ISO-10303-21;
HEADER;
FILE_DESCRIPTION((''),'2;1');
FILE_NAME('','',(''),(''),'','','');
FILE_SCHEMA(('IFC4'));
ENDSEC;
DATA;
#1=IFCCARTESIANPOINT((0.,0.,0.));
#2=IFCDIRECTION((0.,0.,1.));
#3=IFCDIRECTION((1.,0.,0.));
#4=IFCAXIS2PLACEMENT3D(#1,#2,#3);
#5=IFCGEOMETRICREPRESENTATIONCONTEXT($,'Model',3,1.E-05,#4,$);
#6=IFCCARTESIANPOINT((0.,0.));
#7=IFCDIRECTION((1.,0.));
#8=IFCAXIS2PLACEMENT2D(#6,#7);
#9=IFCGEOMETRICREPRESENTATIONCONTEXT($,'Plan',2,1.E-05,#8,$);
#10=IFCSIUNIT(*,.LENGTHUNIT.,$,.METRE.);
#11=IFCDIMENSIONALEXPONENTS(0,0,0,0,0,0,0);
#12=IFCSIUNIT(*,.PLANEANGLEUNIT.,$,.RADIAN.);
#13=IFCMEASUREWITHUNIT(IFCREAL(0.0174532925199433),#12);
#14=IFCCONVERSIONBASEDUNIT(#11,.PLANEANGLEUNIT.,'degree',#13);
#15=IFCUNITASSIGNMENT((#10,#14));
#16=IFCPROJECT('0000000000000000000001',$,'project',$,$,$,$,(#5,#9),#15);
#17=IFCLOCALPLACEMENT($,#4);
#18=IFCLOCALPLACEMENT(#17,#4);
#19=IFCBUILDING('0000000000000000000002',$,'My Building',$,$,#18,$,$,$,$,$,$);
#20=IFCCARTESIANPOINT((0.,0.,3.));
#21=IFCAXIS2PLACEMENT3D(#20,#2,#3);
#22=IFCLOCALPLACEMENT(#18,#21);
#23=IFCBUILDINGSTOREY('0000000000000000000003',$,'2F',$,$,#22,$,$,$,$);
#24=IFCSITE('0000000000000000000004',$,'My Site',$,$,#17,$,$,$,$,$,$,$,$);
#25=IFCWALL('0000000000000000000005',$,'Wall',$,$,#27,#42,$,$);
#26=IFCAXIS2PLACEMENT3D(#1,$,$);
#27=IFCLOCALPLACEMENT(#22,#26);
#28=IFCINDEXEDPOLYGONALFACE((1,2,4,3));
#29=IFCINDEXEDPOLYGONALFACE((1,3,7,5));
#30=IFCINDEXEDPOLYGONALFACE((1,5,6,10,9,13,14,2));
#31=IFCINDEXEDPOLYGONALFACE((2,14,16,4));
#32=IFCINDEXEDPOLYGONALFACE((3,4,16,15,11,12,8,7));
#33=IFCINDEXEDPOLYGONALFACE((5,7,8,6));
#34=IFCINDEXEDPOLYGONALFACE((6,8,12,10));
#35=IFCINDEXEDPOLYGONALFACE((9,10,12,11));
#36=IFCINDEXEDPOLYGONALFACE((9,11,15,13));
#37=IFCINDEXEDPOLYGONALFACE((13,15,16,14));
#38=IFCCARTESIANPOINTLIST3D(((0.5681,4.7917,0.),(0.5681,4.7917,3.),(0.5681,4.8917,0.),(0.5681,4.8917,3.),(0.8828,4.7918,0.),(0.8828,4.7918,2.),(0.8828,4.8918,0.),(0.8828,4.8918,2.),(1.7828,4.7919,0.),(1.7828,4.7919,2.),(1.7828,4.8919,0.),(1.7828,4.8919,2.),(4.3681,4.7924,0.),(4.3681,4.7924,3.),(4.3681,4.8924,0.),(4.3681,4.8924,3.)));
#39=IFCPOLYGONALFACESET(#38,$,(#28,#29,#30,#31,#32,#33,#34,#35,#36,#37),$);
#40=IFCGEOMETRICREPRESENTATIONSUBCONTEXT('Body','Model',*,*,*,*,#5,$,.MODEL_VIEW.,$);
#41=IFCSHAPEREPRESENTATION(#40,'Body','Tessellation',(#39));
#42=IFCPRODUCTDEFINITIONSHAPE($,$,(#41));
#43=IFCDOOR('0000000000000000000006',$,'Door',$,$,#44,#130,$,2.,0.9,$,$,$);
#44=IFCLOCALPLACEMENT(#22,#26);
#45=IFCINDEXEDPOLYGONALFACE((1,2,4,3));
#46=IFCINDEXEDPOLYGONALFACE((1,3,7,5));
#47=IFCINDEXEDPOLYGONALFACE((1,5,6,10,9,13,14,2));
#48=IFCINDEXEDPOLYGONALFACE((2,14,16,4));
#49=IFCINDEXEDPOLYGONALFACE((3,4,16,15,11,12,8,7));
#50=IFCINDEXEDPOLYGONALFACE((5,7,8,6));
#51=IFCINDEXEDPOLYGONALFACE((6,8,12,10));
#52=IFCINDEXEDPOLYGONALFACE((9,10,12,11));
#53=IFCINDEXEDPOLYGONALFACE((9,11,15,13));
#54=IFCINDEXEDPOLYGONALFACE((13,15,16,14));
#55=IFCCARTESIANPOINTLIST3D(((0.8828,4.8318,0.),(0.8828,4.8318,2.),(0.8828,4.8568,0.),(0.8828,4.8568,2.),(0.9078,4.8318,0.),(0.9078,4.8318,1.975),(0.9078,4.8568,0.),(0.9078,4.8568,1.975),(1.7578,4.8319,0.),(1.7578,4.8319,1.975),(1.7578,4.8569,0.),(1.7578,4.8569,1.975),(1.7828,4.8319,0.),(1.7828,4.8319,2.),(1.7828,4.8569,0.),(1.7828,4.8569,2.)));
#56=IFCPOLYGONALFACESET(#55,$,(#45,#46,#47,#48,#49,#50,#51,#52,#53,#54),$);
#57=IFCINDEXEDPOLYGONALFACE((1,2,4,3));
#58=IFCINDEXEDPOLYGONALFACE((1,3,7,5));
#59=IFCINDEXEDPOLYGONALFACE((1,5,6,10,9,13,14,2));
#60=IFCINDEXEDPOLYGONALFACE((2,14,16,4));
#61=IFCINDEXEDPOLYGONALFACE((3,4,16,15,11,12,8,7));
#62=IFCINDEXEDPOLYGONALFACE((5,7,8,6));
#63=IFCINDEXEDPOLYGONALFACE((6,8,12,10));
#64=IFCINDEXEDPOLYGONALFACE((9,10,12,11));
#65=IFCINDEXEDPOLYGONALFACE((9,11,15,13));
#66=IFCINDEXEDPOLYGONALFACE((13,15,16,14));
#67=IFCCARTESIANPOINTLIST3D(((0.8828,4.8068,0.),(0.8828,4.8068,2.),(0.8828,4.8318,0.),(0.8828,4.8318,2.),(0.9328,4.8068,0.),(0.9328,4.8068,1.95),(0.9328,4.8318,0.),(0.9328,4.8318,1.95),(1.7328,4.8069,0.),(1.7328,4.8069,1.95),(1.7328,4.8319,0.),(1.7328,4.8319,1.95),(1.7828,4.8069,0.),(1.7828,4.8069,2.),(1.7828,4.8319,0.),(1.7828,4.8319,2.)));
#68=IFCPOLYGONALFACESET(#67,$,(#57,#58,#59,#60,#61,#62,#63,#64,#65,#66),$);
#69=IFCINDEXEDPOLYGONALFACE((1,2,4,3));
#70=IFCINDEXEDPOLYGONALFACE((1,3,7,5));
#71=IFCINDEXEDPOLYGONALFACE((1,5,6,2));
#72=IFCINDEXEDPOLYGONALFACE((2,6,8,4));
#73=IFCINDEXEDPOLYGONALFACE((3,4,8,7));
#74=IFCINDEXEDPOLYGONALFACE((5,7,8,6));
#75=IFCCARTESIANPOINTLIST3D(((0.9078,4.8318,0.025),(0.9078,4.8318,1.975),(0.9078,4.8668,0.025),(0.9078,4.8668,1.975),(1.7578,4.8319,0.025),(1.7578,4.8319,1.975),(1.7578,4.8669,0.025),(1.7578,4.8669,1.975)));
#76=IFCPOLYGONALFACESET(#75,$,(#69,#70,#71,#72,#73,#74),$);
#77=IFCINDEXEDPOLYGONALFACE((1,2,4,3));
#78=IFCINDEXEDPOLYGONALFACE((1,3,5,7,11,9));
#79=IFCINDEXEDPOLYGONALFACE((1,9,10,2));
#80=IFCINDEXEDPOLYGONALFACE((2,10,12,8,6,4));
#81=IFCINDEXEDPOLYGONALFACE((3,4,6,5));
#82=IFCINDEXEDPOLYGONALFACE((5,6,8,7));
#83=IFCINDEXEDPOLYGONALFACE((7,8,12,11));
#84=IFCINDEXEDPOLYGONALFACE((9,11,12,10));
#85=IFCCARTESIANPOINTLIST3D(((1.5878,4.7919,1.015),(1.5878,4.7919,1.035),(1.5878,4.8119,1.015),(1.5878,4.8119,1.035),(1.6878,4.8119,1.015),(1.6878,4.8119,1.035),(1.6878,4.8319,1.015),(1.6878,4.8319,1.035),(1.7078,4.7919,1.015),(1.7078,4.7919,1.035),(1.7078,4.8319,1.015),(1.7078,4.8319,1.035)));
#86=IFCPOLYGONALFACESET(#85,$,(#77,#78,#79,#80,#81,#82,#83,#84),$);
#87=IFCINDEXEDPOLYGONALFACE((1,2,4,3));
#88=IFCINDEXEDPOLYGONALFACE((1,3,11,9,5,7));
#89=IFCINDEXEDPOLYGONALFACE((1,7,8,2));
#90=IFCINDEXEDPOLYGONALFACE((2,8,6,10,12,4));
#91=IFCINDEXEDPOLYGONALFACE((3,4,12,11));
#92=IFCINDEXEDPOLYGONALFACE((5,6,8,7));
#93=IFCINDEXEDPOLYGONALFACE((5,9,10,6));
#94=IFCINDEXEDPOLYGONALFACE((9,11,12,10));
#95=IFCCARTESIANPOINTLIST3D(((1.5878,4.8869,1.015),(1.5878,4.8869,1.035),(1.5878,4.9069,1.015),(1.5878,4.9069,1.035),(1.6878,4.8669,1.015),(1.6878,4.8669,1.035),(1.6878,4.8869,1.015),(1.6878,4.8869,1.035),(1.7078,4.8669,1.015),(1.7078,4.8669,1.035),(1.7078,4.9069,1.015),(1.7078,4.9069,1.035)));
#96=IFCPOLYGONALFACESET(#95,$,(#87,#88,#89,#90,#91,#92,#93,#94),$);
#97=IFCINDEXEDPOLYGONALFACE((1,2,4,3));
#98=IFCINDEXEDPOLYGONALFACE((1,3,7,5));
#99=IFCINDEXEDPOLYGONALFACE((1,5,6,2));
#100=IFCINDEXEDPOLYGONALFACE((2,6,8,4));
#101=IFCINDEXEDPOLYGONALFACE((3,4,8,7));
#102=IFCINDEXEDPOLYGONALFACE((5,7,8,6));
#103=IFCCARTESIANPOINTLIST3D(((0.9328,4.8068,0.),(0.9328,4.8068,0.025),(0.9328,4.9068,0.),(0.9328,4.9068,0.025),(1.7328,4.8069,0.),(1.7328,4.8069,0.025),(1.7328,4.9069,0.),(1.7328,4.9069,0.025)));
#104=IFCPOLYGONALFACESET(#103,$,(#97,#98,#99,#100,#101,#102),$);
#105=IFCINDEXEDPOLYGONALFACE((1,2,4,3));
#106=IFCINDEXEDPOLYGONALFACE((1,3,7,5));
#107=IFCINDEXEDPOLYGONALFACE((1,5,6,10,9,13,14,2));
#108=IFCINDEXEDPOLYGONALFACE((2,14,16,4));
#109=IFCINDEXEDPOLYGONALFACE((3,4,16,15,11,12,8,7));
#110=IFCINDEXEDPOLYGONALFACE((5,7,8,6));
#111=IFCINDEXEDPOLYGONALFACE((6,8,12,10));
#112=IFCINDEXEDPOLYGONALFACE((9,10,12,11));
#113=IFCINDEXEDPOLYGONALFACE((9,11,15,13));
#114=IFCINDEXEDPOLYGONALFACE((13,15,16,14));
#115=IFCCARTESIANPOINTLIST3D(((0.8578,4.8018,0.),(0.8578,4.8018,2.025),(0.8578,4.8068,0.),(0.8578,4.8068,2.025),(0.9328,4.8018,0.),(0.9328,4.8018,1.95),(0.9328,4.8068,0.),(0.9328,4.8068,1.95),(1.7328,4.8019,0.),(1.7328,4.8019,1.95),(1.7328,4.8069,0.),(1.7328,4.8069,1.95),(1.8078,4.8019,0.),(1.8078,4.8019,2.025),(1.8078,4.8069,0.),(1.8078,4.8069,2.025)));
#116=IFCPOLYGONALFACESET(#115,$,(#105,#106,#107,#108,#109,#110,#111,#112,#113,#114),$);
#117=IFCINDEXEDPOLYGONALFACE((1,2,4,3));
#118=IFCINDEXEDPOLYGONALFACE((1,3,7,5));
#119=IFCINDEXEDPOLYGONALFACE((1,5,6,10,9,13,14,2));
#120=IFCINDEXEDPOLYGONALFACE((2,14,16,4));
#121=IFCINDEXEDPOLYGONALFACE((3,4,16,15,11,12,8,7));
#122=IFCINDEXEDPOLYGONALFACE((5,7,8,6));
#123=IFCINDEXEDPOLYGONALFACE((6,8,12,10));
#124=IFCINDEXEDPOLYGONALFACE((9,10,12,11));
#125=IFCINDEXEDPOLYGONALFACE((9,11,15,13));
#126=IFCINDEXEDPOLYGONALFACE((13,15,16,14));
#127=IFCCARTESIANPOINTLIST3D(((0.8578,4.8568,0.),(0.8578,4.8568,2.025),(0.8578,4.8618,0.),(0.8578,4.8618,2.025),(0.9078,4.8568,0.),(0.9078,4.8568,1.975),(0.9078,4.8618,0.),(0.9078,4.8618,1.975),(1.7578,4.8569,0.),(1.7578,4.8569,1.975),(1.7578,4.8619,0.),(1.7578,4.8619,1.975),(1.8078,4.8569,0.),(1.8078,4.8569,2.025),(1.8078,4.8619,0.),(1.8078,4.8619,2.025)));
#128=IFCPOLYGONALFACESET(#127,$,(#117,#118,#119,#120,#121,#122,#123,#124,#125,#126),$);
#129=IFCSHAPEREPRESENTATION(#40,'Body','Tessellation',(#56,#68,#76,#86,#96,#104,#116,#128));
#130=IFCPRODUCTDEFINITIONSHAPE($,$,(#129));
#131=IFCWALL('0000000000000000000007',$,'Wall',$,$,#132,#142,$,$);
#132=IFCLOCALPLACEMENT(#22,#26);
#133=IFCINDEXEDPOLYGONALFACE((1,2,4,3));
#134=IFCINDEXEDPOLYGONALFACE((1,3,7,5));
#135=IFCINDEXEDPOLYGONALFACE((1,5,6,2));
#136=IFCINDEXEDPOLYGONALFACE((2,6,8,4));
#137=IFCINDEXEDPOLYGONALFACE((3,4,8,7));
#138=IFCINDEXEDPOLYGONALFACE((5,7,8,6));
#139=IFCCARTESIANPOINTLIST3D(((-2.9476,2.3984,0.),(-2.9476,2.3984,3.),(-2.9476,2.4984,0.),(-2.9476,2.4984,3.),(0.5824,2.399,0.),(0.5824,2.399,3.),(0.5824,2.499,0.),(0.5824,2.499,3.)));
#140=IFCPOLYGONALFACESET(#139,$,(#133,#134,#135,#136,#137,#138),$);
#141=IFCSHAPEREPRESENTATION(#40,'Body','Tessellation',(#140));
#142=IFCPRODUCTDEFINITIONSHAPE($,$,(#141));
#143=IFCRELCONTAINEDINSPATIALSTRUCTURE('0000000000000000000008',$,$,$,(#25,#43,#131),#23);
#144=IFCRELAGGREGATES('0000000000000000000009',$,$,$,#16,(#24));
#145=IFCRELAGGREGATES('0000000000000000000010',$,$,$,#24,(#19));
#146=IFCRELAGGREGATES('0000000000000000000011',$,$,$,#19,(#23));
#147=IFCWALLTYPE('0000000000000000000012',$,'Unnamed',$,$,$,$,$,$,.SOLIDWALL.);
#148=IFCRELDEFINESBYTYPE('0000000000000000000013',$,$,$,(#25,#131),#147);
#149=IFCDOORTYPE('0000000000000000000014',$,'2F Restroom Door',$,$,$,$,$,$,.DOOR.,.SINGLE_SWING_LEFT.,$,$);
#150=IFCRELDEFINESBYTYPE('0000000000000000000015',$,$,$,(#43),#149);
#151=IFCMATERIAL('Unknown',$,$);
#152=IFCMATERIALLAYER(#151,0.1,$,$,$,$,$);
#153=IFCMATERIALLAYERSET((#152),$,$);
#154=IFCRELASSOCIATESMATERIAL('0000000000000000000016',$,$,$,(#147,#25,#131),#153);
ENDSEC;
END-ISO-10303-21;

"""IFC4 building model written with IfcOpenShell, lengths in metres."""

from ifc_helpers import new_model, entity, si_unit, converted_unit, frame, origin_with_axes, origin_2d_with_axis, place, context, subcontext, project, spatial, line, indexed_curve, outline, extrude, shape, source, transform, mapped, material, layer, layer_set, layer_usage, type_object, type_shapes, element, fill, save


model = new_model("IFC4")

# Units and contexts
model_context = context("Model", 3, precision=1e-05, world=origin_with_axes())
plan_context = context("Plan", 2, precision=1e-05, world=origin_2d_with_axis())
body_context_1 = subcontext(model_context, "Body", "Model", "MODEL_VIEW")
body_context_2 = subcontext(plan_context, "Body", "Plan", "PLAN_VIEW")
ifc_project = project(units=[si_unit("LENGTHUNIT", "METRE"), converted_unit("PLANEANGLEUNIT", "degree", entity("IfcReal", 0.0174532925199433), si_unit("PLANEANGLEUNIT", "RADIAN"), dimensions=[0, 0, 0, 0, 0, 0, 0])], contexts=[model_context, plan_context])

# Site, building, storey
site_placement = place(None, origin_with_axes())
site = spatial("IfcSite", under=ifc_project, at=site_placement, Name="My Site")
building_placement = place(site_placement, origin_with_axes())
building = spatial("IfcBuilding", under=site, at=building_placement, Name="My Building")
storey_placement = place(building_placement, frame((0.0, 0.0, 3.0), z_axis=(0.0, 0.0, 1.0), x_axis=(1.0, 0.0, 0.0)))
storey = spatial("IfcBuildingStorey", under=building, at=storey_placement, Name="2F")

# Shared definitions
ifc_material = material(Name="Unknown")

# Shared definitions
ifc_layer = layer(ifc_material, 0.1)
ifc_layer_set = layer_set([ifc_layer])
wall_type = type_object("IfcWallType", Name="Unnamed", PredefinedType="SOLIDWALL", material=ifc_layer_set)

# Wall, opening, door
ifc_layer_usage_1 = layer_usage(ifc_layer_set, "AXIS2", "POSITIVE", 0.0)
wall_1_placement = place(storey_placement, frame((4.3681, 4.8924, 0.0), z_axis=(0.0, 0.0, 1.0), x_axis=(-1.0, -0.000193, 0.0)))
wall_1 = element("IfcWall", 1, at=wall_1_placement, inside=storey, type_object=wall_type, material=ifc_layer_usage_1, Name="Wall", context=body_context_1, shape_type="SweptSolid", body=[
    extrude(outline(indexed_curve([(0.0, 0.0), (0.0, 0.1), (3.8, 0.1), (3.8, 0.0)], segments=[line(1, 2, 3, 4, 1)])), origin_with_axes(), (0.0, 0.0, 1.0), 3.0),
])
shared_shape_1 = source(origin_with_axes(), body_context_1, "Body", "SweptSolid", [
    extrude(outline(indexed_curve([(0.0, 0.0), (0.9, 0.0), (0.9, 2.0), (0.0, 2.0)], segments=[line(1, 2, 3, 4, 1)])), frame((0.0, -0.6, 0.0), z_axis=(0.0, -1.0, 0.0), x_axis=(1.0, 0.0, 0.0)), (0.0, 0.0, -1.0), 1.2),
])
opening_1_placement = place(wall_1_placement, frame((2.5853, 0.0, 0.0), z_axis=(0.0, 0.0, 1.0), x_axis=(1.0, 0.0, 0.0)))
opening_1 = element("IfcOpeningElement", 2, at=opening_1_placement, cuts=wall_1, PredefinedType="OPENING", context=body_context_1, shape_type="MappedRepresentation", body=[
    mapped(shared_shape_1, transform((0.0, 0.0, 0.0), x_axis=(1.0, 0.0, 0.0), y_axis=(0.0, 1.0, 0.0), z_axis=(0.0, 0.0, 1.0), scale=1.0)),
])
door_type_1 = type_object("IfcDoorType", Name="2F Restroom Door", OperationType="SINGLE_SWING_LEFT", PredefinedType="DOOR")
shared_shape_2 = source(origin_with_axes(), body_context_1, "Body", "SweptSolid", [
    extrude(outline(indexed_curve([(0.0, 0.0), (0.0, 2.0), (0.9, 2.0), (0.9, 0.0), (0.875, 0.0), (0.875, 1.975), (0.025, 1.975), (0.025, 0.0)], segments=[line(1, 2, 3, 4, 5, 6, 7, 8, 1)])), frame((0.0, 0.025, 0.0), z_axis=(0.0, -1.0, 0.0), x_axis=(1.0, 0.0, 0.0)), (0.0, 0.0, -1.0), 0.025),
    extrude(outline(indexed_curve([(0.0, 0.0), (0.0, 2.0), (0.9, 2.0), (0.9, 0.0), (0.85, 0.0), (0.85, 1.95), (0.05, 1.95), (0.05, 0.0)], segments=[line(1, 2, 3, 4, 5, 6, 7, 8, 1)])), frame((0.0, 0.0, 0.0), z_axis=(0.0, -1.0, 0.0), x_axis=(1.0, 0.0, 0.0)), (0.0, 0.0, -1.0), 0.025),
    extrude(outline(indexed_curve([(0.0, 0.0), (0.85, 0.0), (0.85, 0.035), (0.0, 0.035)], segments=[line(1, 2, 3, 4, 1)])), frame((0.025, 0.025, 0.025), z_axis=(0.0, 0.0, 1.0), x_axis=(1.0, 0.0, 0.0)), (0.0, 0.0, 1.0), 1.95),
    extrude(outline(indexed_curve([(0.0, 0.0), (0.0, -0.04), (-0.12, -0.04), (-0.12, -0.02), (-0.02, -0.02), (-0.02, 0.0)], segments=[line(1, 2, 3, 4, 5, 6, 1)])), frame((0.825, 0.025, 1.015), z_axis=(0.0, 0.0, 1.0), x_axis=(1.0, 0.0, 0.0)), (0.0, 0.0, 1.0), 0.02),
    extrude(outline(indexed_curve([(0.0, 0.0), (0.0, 0.04), (-0.12, 0.04), (-0.12, 0.02), (-0.02, 0.02), (-0.02, 0.0)], segments=[line(1, 2, 3, 4, 5, 6, 1)])), frame((0.825, 0.06, 1.015), z_axis=(0.0, 0.0, 1.0), x_axis=(1.0, 0.0, 0.0)), (0.0, 0.0, 1.0), 0.02),
    extrude(outline(indexed_curve([(0.0, 0.0), (0.8, 0.0), (0.8, 0.1), (0.0, 0.1)], segments=[line(1, 2, 3, 4, 1)])), frame((0.05, 0.0, 0.0), z_axis=(0.0, 0.0, 1.0), x_axis=(1.0, 0.0, 0.0)), (0.0, 0.0, 1.0), 0.025),
    extrude(outline(indexed_curve([(0.0, 0.0), (0.0, 2.025), (0.95, 2.025), (0.95, 0.0), (0.875, 0.0), (0.875, 1.95), (0.075, 1.95), (0.075, 0.0)], segments=[line(1, 2, 3, 4, 5, 6, 7, 8, 1)])), frame((-0.025, -0.005, 0.0), z_axis=(0.0, -1.0, 0.0), x_axis=(1.0, 0.0, 0.0)), (0.0, 0.0, -1.0), 0.005),
    extrude(outline(indexed_curve([(0.0, 0.0), (0.0, 2.025), (0.95, 2.025), (0.95, 0.0), (0.9, 0.0), (0.9, 1.975), (0.05, 1.975), (0.05, 0.0)], segments=[line(1, 2, 3, 4, 5, 6, 7, 8, 1)])), frame((-0.025, 0.05, 0.0), z_axis=(0.0, -1.0, 0.0), x_axis=(1.0, 0.0, 0.0)), (0.0, 0.0, -1.0), 0.005),
])
shared_shape_3 = source(origin_with_axes(), body_context_2, "Body", "Curve2D", [
    entity("IfcIndexedPolyCurve", entity("IfcCartesianPointList2D", [[0.0, 0.0], [0.0, 0.05], [0.025, 0.05], [0.025, 0.025], [0.05, 0.025], [0.05, 0.0]]), [entity("IfcLineIndex", [1, 2, 3, 4, 5, 6, 1])]),
    entity("IfcIndexedPolyCurve", entity("IfcCartesianPointList2D", [[0.9, 0.0], [0.9, 0.05], [0.875, 0.05], [0.875, 0.025], [0.85, 0.025], [0.85, 0.0]]), [entity("IfcLineIndex", [1, 2, 3, 4, 5, 6, 1])]),
    entity("IfcTrimmedCurve", entity("IfcEllipse", entity("IfcAxis2Placement2D", entity("IfcCartesianPoint", [0.06, 0.05]), entity("IfcDirection", [1.0, 0.0])), 0.815, 0.85), [entity("IfcCartesianPoint", [0.875, 0.05])], [entity("IfcCartesianPoint", [0.06, 0.9])], True, "CARTESIAN"),
    entity("IfcIndexedPolyCurve", entity("IfcCartesianPointList2D", [[0.025, 0.05], [0.06, 0.05], [0.06, 0.9], [0.025, 0.9]]), [entity("IfcLineIndex", [1, 2, 3, 4, 1])]),
])
type_shapes(door_type_1, [shared_shape_2, shared_shape_3])
door_1_placement = place(opening_1_placement, frame((0.9, 0.085, 0.0), z_axis=(0.0, 0.0, 1.0), x_axis=(-1.0, 0.0, 0.0)))
door_1 = element("IfcDoor", 3, at=door_1_placement, inside=storey, type_object=door_type_1, Name="Door", OverallHeight=2.0, OverallWidth=0.9, shapes=[
    shape(body_context_1, "Body", "MappedRepresentation", [mapped(shared_shape_2, transform((0.0, 0.0, 0.0), x_axis=(1.0, 0.0, 0.0), y_axis=(0.0, 1.0, 0.0), z_axis=(0.0, 0.0, 1.0), scale=1.0))]),
    shape(body_context_2, "Body", "MappedRepresentation", [mapped(shared_shape_3, transform((0.0, 0.0, 0.0), x_axis=(1.0, 0.0, 0.0), y_axis=(0.0, 1.0, 0.0), z_axis=(0.0, 0.0, 1.0), scale=1.0))]),
])
fill(opening_1, door_1)

# Wall
ifc_layer_usage_2 = layer_usage(ifc_layer_set, "AXIS2", "POSITIVE", 0.0)
wall_2_placement = place(storey_placement, frame((0.5824, 2.499, 0.0), z_axis=(0.0, 0.0, 1.0), x_axis=(-1.0, -0.000177, 0.0)))
element("IfcWall", 4, at=wall_2_placement, inside=storey, type_object=wall_type, material=ifc_layer_usage_2, Name="Wall", context=body_context_1, shape_type="SweptSolid", body=[
    extrude(outline(indexed_curve([(0.0, 0.0), (0.0, 0.1), (3.53, 0.1), (3.53, 0.0)], segments=[line(1, 2, 3, 4, 1)])), origin_with_axes(), (0.0, 0.0, 1.0), 3.0),
])

save(model, "model.ifc")
